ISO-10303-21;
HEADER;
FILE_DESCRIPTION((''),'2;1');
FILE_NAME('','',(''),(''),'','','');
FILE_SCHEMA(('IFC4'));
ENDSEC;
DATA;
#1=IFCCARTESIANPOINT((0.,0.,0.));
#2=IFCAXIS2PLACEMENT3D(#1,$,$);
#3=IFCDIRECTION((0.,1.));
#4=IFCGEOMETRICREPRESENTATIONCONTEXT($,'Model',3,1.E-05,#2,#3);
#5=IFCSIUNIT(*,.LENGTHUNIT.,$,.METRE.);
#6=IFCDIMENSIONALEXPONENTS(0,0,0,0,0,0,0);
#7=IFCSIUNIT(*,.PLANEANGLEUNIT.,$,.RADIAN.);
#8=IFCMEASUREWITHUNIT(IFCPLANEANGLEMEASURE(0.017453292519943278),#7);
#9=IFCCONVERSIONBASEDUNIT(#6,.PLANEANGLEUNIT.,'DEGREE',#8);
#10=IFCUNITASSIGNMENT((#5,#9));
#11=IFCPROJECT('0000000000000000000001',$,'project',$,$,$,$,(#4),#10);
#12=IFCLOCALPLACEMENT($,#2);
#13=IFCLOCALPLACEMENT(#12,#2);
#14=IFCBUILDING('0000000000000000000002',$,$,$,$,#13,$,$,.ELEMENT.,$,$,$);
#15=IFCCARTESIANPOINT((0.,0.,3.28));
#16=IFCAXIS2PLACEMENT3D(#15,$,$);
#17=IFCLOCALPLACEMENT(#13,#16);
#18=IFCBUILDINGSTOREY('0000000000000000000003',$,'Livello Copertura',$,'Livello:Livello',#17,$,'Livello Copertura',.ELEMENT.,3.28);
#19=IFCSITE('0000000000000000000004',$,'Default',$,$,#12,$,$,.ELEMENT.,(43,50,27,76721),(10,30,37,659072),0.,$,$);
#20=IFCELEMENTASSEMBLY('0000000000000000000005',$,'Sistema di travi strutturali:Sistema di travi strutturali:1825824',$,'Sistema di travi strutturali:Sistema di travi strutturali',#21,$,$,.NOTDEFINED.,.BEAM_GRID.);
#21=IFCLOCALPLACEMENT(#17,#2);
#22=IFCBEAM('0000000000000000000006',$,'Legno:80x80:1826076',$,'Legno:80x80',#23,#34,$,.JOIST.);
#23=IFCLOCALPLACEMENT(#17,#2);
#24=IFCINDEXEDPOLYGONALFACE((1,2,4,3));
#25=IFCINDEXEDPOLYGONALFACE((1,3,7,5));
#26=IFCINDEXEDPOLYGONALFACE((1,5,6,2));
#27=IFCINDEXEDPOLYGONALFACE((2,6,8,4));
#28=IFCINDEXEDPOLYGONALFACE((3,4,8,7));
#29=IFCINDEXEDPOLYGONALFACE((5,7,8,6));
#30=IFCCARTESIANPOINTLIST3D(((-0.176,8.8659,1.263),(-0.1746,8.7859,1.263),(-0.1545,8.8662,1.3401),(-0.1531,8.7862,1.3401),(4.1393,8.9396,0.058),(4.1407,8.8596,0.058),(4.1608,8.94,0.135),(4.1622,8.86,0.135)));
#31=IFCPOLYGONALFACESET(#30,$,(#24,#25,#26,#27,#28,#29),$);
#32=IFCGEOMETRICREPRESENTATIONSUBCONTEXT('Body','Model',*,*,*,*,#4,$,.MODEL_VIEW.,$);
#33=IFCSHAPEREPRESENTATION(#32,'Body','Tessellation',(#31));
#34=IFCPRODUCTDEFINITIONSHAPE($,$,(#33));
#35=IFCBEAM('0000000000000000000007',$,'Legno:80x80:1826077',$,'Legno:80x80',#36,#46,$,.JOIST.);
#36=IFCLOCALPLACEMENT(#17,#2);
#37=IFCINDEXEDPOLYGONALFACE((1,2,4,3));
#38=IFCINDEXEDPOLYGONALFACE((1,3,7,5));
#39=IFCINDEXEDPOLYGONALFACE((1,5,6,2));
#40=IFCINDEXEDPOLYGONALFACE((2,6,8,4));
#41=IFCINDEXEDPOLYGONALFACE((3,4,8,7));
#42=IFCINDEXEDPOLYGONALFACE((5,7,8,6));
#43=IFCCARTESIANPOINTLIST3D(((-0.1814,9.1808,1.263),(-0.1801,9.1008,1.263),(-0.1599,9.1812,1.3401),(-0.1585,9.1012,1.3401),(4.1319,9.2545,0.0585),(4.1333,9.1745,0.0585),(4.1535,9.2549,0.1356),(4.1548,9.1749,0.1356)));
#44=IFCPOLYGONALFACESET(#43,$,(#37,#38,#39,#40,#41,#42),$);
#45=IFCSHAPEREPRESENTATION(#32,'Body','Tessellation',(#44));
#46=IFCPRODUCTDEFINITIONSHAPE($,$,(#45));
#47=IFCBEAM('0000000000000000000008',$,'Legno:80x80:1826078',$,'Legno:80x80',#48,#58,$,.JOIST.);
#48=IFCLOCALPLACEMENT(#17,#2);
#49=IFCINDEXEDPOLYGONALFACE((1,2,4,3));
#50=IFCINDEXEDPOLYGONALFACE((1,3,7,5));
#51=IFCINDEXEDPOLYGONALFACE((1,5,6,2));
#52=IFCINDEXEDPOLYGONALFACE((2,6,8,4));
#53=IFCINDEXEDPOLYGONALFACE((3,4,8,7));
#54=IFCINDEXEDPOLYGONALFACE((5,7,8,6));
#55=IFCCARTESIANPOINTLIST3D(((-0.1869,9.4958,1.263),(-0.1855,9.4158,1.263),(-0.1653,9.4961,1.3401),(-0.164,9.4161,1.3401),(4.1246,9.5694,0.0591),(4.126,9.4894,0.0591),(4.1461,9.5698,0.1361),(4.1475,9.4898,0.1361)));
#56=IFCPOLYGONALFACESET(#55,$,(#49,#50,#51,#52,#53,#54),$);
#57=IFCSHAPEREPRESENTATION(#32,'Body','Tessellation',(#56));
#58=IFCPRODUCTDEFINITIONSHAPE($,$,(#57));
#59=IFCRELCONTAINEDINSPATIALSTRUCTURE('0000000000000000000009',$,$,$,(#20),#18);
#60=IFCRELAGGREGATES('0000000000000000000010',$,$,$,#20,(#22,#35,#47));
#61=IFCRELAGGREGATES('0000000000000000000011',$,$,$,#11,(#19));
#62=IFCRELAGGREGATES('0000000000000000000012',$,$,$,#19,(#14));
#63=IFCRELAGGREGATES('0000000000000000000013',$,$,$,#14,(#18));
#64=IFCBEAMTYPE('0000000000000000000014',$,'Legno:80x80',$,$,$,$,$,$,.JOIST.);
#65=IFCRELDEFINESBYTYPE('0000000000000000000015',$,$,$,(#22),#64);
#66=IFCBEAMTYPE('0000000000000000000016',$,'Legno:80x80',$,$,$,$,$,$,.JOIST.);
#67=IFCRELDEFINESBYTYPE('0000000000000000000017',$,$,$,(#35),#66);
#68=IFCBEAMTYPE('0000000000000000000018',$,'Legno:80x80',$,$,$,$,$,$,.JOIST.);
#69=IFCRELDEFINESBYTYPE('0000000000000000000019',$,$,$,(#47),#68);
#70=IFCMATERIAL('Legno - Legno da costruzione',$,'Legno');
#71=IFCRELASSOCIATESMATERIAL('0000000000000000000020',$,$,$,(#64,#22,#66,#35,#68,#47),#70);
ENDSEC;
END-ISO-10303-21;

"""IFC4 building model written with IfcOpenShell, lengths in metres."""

from ifc_helpers import new_model, entity, si_unit, converted_unit, direction, frame, origin, place, context, subcontext, project, spatial, indexed_curve, outline, extrude, source, transform, mapped, material, type_object, type_shapes, element, aggregate, save


model = new_model("IFC4")

# Units and contexts
model_context = context("Model", 3, precision=1e-05, world=origin(), true_north=direction((0.0, 1.0)))
body_context = subcontext(model_context, "Body", "Model", "MODEL_VIEW")
ifc_project = project(units=[si_unit("LENGTHUNIT", "METRE"), converted_unit("PLANEANGLEUNIT", "DEGREE", entity("IfcPlaneAngleMeasure", 0.017453292519943278), si_unit("PLANEANGLEUNIT", "RADIAN"), dimensions=[0, 0, 0, 0, 0, 0, 0])], contexts=[model_context])

# Site, building, storey
site_placement = place(None, origin())
site = spatial("IfcSite", under=ifc_project, at=site_placement, Name="Default", CompositionType="ELEMENT", RefLatitude=(43, 50, 27, 76721), RefLongitude=(10, 30, 37, 659072), RefElevation=0.0)
building_placement = place(site_placement, origin())
building = spatial("IfcBuilding", under=site, at=building_placement, CompositionType="ELEMENT")
storey_placement = place(building_placement, frame((0.0, 0.0, 3.28)))
storey = spatial("IfcBuildingStorey", under=building, at=storey_placement, Name="Livello Copertura", ObjectType="Livello:Livello", LongName="Livello Copertura", CompositionType="ELEMENT", Elevation=3.28)

# Shared definitions
ifc_material_1 = material(Name="Legno - Legno da costruzione", Category="Legno")

# Element assembly, beams
assembly_1_placement = place(storey_placement, origin())
assembly_1 = element("IfcElementAssembly", 1, at=assembly_1_placement, inside=storey, Name="Sistema di travi strutturali:Sistema di travi strutturali:1825824", ObjectType="Sistema di travi strutturali:Sistema di travi strutturali", AssemblyPlace="NOTDEFINED", PredefinedType="BEAM_GRID")
beam_type_1 = type_object("IfcBeamType", Name="Legno:80x80", PredefinedType="JOIST", material=ifc_material_1)
shared_shape_1 = source(origin(), body_context, "Body", "SweptSolid", [
    extrude(outline(indexed_curve([(-2.2405, -0.04), (2.2405, -0.04), (2.2405, 0.04), (-2.2405, 0.04), (-2.2405, -0.04)], self_intersect=False)), frame((0.0, 0.0, -0.04), z_axis=(0.0, 0.0, 1.0), x_axis=(-1.0, 0.0, 0.0)), (0.0, 0.0, 1.0), 0.08),
])
type_shapes(beam_type_1, [shared_shape_1])
beam_1_placement = place(assembly_1_placement, frame((1.9931, 8.8629, 0.699), z_axis=(0.268881, 0.004594, 0.963163), x_axis=(-0.963022, -0.016456, 0.26892)))
beam_1 = element("IfcBeam", 2, at=beam_1_placement, type_object=beam_type_1, material=ifc_material_1, Name="Legno:80x80:1826076", ObjectType="Legno:80x80", PredefinedType="JOIST", context=body_context, shape_type="MappedRepresentation", body=[
    mapped(shared_shape_1, transform((0.0, 0.0, 0.0), scale=1.0)),
])
beam_type_2 = type_object("IfcBeamType", Name="Legno:80x80", PredefinedType="JOIST", material=ifc_material_1)
shared_shape_2 = source(origin(), body_context, "Body", "SweptSolid", [
    extrude(outline(indexed_curve([(-2.2395, -0.04), (2.2395, -0.04), (2.2395, 0.04), (-2.2395, 0.04), (-2.2395, -0.04)], self_intersect=False)), frame((0.0, 0.0, -0.04), z_axis=(0.0, 0.0, 1.0), x_axis=(-1.0, 0.0, 0.0)), (0.0, 0.0, 1.0), 0.08),
])
type_shapes(beam_type_2, [shared_shape_2])
beam_2_placement = place(assembly_1_placement, frame((1.9867, 9.1778, 0.6993), z_axis=(0.268881, 0.004594, 0.963163), x_axis=(-0.963022, -0.016456, 0.26892)))
beam_2 = element("IfcBeam", 3, at=beam_2_placement, type_object=beam_type_2, material=ifc_material_1, Name="Legno:80x80:1826077", ObjectType="Legno:80x80", PredefinedType="JOIST", context=body_context, shape_type="MappedRepresentation", body=[
    mapped(shared_shape_2, transform((0.0, 0.0, 0.0), scale=1.0)),
])
beam_type_3 = type_object("IfcBeamType", Name="Legno:80x80", PredefinedType="JOIST", material=ifc_material_1)
shared_shape_3 = source(origin(), body_context, "Body", "SweptSolid", [
    extrude(outline(indexed_curve([(-2.2385, -0.04), (2.2385, -0.04), (2.2385, 0.04), (-2.2385, 0.04), (-2.2385, -0.04)], self_intersect=False)), frame((0.0, 0.0, -0.04), z_axis=(0.0, 0.0, 1.0), x_axis=(-1.0, 0.0, 0.0)), (0.0, 0.0, 1.0), 0.08),
])
type_shapes(beam_type_3, [shared_shape_3])
beam_3_placement = place(assembly_1_placement, frame((1.9803, 9.4928, 0.6996), z_axis=(0.268881, 0.004594, 0.963163), x_axis=(-0.963022, -0.016456, 0.26892)))
beam_3 = element("IfcBeam", 4, at=beam_3_placement, type_object=beam_type_3, material=ifc_material_1, Name="Legno:80x80:1826078", ObjectType="Legno:80x80", PredefinedType="JOIST", context=body_context, shape_type="MappedRepresentation", body=[
    mapped(shared_shape_3, transform((0.0, 0.0, 0.0), scale=1.0)),
])
aggregate(assembly_1, [beam_1, beam_2, beam_3])

save(model, "model.ifc")
